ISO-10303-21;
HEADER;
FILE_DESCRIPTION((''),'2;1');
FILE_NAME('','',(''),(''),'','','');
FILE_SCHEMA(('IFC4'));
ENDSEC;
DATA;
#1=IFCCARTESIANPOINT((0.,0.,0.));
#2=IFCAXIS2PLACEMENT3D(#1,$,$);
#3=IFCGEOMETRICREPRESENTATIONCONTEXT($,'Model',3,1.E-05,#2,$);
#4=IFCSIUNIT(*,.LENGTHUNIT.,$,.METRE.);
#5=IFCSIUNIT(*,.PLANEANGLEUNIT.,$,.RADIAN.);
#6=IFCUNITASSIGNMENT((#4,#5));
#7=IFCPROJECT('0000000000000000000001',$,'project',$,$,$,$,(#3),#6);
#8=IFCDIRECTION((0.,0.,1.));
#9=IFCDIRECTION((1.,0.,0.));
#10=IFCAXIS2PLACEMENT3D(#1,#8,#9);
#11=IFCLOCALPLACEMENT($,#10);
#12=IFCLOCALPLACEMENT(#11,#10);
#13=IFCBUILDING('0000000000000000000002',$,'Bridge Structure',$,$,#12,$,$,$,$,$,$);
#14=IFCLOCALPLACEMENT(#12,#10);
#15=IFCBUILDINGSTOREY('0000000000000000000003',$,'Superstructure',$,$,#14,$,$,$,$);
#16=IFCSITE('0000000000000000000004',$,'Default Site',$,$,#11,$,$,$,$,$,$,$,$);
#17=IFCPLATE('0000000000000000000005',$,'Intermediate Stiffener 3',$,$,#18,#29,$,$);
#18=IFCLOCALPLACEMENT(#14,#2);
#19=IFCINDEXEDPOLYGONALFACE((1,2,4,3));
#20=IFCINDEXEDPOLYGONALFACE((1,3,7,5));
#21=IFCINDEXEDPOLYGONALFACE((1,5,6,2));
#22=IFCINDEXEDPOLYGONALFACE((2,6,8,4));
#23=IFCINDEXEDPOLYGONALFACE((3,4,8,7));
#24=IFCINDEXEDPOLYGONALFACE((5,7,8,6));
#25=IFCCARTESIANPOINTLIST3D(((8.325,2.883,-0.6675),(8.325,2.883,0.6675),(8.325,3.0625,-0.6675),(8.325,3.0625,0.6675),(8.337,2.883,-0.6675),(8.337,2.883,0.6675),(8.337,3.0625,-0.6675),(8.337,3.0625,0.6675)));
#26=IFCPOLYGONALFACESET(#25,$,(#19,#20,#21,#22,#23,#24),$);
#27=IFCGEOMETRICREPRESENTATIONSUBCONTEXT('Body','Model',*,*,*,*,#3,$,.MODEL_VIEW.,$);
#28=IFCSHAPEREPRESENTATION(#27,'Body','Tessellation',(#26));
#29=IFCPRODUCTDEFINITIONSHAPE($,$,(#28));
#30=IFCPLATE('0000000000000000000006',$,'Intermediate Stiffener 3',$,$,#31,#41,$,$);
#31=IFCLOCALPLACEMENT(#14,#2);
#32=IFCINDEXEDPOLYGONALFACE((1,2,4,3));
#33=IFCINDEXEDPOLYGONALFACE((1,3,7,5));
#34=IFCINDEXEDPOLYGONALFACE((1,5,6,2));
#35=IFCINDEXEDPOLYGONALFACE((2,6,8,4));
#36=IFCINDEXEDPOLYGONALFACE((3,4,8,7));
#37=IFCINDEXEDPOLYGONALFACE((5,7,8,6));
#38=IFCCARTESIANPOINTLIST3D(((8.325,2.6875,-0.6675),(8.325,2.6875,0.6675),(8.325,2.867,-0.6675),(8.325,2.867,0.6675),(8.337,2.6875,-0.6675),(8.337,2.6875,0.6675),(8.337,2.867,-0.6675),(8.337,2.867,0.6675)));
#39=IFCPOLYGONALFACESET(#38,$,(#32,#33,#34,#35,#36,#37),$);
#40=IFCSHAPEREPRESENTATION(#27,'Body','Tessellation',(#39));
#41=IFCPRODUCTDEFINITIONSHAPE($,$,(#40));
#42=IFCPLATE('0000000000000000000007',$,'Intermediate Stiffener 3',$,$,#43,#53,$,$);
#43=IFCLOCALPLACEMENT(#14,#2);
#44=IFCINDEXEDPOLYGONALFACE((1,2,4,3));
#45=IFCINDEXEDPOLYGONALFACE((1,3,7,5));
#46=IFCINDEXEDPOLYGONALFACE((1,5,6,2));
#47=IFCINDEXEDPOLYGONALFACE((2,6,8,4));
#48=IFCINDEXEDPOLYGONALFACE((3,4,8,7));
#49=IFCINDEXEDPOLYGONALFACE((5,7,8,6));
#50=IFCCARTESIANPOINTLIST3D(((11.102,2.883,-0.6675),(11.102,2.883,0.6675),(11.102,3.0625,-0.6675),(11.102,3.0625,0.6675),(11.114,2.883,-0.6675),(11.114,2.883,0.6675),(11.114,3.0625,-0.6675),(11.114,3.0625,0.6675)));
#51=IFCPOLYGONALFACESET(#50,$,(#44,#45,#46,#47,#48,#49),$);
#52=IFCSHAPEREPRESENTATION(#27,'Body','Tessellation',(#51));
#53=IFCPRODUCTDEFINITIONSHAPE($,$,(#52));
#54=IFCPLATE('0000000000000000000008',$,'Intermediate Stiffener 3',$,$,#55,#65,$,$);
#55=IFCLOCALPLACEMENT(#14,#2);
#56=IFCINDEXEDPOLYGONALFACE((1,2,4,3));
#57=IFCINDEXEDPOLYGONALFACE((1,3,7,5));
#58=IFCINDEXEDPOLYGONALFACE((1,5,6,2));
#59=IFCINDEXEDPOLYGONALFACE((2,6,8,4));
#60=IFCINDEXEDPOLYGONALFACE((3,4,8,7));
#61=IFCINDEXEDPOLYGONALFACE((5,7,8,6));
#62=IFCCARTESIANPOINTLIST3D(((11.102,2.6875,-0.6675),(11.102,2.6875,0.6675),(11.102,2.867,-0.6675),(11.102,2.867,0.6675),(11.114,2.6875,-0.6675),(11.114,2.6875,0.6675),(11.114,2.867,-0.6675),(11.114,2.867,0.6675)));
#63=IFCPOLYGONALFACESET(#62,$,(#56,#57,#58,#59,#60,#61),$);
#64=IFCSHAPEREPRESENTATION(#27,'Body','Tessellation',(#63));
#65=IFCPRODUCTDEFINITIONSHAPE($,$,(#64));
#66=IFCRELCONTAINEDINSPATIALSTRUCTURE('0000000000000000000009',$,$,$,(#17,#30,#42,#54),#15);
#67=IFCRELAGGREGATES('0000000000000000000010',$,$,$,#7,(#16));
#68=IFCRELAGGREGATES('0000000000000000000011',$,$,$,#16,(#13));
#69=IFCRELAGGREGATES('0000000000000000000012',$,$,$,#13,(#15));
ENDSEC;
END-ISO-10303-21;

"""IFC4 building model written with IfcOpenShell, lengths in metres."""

from ifc_helpers import new_model, si_unit, frame, origin, origin_with_axes, origin_2d_with_axis, place, context, subcontext, project, spatial, rectangle, extrude, element, save


model = new_model("IFC4")

# Units and contexts
model_context = context("Model", 3, precision=1e-05, world=origin())
body_context = subcontext(model_context, "Body", "Model", "MODEL_VIEW")
ifc_project = project(units=[si_unit("LENGTHUNIT", "METRE"), si_unit("PLANEANGLEUNIT", "RADIAN")], contexts=[model_context])

# Site, building, storey
site_placement = place(None, origin_with_axes())
site = spatial("IfcSite", under=ifc_project, at=site_placement, Name="Default Site")
building_placement = place(site_placement, origin_with_axes())
building = spatial("IfcBuilding", under=site, at=building_placement, Name="Bridge Structure")
storey_placement = place(building_placement, origin_with_axes())
storey = spatial("IfcBuildingStorey", under=building, at=storey_placement, Name="Superstructure")

# Plates
for number, where, z_axis, x_axis, name in (
    (1, (8.331, 2.9728, -0.6675), (0.0, 0.0, 1.0), (1.0, 0.0, 0.0), "Intermediate Stiffener 3"),
    (2, (8.331, 2.7772, -0.6675), (0.0, 0.0, 1.0), (1.0, 0.0, 0.0), "Intermediate Stiffener 3"),
    (3, (11.108, 2.9728, -0.6675), (0.0, 0.0, 1.0), (1.0, 0.0, 0.0), "Intermediate Stiffener 3"),
    (4, (11.108, 2.7772, -0.6675), (0.0, 0.0, 1.0), (1.0, 0.0, 0.0), "Intermediate Stiffener 3"),
):
    element("IfcPlate", number, at=place(storey_placement, frame(where, z_axis=z_axis, x_axis=x_axis)), inside=storey, Name=name, context=body_context, shape_type="SweptSolid", body=[
        extrude(rectangle(XDim=0.012, YDim=0.1795, at=origin_2d_with_axis()), origin_with_axes(), (0.0, 0.0, 1.0), 1.335),
    ])

save(model, "model.ifc")
